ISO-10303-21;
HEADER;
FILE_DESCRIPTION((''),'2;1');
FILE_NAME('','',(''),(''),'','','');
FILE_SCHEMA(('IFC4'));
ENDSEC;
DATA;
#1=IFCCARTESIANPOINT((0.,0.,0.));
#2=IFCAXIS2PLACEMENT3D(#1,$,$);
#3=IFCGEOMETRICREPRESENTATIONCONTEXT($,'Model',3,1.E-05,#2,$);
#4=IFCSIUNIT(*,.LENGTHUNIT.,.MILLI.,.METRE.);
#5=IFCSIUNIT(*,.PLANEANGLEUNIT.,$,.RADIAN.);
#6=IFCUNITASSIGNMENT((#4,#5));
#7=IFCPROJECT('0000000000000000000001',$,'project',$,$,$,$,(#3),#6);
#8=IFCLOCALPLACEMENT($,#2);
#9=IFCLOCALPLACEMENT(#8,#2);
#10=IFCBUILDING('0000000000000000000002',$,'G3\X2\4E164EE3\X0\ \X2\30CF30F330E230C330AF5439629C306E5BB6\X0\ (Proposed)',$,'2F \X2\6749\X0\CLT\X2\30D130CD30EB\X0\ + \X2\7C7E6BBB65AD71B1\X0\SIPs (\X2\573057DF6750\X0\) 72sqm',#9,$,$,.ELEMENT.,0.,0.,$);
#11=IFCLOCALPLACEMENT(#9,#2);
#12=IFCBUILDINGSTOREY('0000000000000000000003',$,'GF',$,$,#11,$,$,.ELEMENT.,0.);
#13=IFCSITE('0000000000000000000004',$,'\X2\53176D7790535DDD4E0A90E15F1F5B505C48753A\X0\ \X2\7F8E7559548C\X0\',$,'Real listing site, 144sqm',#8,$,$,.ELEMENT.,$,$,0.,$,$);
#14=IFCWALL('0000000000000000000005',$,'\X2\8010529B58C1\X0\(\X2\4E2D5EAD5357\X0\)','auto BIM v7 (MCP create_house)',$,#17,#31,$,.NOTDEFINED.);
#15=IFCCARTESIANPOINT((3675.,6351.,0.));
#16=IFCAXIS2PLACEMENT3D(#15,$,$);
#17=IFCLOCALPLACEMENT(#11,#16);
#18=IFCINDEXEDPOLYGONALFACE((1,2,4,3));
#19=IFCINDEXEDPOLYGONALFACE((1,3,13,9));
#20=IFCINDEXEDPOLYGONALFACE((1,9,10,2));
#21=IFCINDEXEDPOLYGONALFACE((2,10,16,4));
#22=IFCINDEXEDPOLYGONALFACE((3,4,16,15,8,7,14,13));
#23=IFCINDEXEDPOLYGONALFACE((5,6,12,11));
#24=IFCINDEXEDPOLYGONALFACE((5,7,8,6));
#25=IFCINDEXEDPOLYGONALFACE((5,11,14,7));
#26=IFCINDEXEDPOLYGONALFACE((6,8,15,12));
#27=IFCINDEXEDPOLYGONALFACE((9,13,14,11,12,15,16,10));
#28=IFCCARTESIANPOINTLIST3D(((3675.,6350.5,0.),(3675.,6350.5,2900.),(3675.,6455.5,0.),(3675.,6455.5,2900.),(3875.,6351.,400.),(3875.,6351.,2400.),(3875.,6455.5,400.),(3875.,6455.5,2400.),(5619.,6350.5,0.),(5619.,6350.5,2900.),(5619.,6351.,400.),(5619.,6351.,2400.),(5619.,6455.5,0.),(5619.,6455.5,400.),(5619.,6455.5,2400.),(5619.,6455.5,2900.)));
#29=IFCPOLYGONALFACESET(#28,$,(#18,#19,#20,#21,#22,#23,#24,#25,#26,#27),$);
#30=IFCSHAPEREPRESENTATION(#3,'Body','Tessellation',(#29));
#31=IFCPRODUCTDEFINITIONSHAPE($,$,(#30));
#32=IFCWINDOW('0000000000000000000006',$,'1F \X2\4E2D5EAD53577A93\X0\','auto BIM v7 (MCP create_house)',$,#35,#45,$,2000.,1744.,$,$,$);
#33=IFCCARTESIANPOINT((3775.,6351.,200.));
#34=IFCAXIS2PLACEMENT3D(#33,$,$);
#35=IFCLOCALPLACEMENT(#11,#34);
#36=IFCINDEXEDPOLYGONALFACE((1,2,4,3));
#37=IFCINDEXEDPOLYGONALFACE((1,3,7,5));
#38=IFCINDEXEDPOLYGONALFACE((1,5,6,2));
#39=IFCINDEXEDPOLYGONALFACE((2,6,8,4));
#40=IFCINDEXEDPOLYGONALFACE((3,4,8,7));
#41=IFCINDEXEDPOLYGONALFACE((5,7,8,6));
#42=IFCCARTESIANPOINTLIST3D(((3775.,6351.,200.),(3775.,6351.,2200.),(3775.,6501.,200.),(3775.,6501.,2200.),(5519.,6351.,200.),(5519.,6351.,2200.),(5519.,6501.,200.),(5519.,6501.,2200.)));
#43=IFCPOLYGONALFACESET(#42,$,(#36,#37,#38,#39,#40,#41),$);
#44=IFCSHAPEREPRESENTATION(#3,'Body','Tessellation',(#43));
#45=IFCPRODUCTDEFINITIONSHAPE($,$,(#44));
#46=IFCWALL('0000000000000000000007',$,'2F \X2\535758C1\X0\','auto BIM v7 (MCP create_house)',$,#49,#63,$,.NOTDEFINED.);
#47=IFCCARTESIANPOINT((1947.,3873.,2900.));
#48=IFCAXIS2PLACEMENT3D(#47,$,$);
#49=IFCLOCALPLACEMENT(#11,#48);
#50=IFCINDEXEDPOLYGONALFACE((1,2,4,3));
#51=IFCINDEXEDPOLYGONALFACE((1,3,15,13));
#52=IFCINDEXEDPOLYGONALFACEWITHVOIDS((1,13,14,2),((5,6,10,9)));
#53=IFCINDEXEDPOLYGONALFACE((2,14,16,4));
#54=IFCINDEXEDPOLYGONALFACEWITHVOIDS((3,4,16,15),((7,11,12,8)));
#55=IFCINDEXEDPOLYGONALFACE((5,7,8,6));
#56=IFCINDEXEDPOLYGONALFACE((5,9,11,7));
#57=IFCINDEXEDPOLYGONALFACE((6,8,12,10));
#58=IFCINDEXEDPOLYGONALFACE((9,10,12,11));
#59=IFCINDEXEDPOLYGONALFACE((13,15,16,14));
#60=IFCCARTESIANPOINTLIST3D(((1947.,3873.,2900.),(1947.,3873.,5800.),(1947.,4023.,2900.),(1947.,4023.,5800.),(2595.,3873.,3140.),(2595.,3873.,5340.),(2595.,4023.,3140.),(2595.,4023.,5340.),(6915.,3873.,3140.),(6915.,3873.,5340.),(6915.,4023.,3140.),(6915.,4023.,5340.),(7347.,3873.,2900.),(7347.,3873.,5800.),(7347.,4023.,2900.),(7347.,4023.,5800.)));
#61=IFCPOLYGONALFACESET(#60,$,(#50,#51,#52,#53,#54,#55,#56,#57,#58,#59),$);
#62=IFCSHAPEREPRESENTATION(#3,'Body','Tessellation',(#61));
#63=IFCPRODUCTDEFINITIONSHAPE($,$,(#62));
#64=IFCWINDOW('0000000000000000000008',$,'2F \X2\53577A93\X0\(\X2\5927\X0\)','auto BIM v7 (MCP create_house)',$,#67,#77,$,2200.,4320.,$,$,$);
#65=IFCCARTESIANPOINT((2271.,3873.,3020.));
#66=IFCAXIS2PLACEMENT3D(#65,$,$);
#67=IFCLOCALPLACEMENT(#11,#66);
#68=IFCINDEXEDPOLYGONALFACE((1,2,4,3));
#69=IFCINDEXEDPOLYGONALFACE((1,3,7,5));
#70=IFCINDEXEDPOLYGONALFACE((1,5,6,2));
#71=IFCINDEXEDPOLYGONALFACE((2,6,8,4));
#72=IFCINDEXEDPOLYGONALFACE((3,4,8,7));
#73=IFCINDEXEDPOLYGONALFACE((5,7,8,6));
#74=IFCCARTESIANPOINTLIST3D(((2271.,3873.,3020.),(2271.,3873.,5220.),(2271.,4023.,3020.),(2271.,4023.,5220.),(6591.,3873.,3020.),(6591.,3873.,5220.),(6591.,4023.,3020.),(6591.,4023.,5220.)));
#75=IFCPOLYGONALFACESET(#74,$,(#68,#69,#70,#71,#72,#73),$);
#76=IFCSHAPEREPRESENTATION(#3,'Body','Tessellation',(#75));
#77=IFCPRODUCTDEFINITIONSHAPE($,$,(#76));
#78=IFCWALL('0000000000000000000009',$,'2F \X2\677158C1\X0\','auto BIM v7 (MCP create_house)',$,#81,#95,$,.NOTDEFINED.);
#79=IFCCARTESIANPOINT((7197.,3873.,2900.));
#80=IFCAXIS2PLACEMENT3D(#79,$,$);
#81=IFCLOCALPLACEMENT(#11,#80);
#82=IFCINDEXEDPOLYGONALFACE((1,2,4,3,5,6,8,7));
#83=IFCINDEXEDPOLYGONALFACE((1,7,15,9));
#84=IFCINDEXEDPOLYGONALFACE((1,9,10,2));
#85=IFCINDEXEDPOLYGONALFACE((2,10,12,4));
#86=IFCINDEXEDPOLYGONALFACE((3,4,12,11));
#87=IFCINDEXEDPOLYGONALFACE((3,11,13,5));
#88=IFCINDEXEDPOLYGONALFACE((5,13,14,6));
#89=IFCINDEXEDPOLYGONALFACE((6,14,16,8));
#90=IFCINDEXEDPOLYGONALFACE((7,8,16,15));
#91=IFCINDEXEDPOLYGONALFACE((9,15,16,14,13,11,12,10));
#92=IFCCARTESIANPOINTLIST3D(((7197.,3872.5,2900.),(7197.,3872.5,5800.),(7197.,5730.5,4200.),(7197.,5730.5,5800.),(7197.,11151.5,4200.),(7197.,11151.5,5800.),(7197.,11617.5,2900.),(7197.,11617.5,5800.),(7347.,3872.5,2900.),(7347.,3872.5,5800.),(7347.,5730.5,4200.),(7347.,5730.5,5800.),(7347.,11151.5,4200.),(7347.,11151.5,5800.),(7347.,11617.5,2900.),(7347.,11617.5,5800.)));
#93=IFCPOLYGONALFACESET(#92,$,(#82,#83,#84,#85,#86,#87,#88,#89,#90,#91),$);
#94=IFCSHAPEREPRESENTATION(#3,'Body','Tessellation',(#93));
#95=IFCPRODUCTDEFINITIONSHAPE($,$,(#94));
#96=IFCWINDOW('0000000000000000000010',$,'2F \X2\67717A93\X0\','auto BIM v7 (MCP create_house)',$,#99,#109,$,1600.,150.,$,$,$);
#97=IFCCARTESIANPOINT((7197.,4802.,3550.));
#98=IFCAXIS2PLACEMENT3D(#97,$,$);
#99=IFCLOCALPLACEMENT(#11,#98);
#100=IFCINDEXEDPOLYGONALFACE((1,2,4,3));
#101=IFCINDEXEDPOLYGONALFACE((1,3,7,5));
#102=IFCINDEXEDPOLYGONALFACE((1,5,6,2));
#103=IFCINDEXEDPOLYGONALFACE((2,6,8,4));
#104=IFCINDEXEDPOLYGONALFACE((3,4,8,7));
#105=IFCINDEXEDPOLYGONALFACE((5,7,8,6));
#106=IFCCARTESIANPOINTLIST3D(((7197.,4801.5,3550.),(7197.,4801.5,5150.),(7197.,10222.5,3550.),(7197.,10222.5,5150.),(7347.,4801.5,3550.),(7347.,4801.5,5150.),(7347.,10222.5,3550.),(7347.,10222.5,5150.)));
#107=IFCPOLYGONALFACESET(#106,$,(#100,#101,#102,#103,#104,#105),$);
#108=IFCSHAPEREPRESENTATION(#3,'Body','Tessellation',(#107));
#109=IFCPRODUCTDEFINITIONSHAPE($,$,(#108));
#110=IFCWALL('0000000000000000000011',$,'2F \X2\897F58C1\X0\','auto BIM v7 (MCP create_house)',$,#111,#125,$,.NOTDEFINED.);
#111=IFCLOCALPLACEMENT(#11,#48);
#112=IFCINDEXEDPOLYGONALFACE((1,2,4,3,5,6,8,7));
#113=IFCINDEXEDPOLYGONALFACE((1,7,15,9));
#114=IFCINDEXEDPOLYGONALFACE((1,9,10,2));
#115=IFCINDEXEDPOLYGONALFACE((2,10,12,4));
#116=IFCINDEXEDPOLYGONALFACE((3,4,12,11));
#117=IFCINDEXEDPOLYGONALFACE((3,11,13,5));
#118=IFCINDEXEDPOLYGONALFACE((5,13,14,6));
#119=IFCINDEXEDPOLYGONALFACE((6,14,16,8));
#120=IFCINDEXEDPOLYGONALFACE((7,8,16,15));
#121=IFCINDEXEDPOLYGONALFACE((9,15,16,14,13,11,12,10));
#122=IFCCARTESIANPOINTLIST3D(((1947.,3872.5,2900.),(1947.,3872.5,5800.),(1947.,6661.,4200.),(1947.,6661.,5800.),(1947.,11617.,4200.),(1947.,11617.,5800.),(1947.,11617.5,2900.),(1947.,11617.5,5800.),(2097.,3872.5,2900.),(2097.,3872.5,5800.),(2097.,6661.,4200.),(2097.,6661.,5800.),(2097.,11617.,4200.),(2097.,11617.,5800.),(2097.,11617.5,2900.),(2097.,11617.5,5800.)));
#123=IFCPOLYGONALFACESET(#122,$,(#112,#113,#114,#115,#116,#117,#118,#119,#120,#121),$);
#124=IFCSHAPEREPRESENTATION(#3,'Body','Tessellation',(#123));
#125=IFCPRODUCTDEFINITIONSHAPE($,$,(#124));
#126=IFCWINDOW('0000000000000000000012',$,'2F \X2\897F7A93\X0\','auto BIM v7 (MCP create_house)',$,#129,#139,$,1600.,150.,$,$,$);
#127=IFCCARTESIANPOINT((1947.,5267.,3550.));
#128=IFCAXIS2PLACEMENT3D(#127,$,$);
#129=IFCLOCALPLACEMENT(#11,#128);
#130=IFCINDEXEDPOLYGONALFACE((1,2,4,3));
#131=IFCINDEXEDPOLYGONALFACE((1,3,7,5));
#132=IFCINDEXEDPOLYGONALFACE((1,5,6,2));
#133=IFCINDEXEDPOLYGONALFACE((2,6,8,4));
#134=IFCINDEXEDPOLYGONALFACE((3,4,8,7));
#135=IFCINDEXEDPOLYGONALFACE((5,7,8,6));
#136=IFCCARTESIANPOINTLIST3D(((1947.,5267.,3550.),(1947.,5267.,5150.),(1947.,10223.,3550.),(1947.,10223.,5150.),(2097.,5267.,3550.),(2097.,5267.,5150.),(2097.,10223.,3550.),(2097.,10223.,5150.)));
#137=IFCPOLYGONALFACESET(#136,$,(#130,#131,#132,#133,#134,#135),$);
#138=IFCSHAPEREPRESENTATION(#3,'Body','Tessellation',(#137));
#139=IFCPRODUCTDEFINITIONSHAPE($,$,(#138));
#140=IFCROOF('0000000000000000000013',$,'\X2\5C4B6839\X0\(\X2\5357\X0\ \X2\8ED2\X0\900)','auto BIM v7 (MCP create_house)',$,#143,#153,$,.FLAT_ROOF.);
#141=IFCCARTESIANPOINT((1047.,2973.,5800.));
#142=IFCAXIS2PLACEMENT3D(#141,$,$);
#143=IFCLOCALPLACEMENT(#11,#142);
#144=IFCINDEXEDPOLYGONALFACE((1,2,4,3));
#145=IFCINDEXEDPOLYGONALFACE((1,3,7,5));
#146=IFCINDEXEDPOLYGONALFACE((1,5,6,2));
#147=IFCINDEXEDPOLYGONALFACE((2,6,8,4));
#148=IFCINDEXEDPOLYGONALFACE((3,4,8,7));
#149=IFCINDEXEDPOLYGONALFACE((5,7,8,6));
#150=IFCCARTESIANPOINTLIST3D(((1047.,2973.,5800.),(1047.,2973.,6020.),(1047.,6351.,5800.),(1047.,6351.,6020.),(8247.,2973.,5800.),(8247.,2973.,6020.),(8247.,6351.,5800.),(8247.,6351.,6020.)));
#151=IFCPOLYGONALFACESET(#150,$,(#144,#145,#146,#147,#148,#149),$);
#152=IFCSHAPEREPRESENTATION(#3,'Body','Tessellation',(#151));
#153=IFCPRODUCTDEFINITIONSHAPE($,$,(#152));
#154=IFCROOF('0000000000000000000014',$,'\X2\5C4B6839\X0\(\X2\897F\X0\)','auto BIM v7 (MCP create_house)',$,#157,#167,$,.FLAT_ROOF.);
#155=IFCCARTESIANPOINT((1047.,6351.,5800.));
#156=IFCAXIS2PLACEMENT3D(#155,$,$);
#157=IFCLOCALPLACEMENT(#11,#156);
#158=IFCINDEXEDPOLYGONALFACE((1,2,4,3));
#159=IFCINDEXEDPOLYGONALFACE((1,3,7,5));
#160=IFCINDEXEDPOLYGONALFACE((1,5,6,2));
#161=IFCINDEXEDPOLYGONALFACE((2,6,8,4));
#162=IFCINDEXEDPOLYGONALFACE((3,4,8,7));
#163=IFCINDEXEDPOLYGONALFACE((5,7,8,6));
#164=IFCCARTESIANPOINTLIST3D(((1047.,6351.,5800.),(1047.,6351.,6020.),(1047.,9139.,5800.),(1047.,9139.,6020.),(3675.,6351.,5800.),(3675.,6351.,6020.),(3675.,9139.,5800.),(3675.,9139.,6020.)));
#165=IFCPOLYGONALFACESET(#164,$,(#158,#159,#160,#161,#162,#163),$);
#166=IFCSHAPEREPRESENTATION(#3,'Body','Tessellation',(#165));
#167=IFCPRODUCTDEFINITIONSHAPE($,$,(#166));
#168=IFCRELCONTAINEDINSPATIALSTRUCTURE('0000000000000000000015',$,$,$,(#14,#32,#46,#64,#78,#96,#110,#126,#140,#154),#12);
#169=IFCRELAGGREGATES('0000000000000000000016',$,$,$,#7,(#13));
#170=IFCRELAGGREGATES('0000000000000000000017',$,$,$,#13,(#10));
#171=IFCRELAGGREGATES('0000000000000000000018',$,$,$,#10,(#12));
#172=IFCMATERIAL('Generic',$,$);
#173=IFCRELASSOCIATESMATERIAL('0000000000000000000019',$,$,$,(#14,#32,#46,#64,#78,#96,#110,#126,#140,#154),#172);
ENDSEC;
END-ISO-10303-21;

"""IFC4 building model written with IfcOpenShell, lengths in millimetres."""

from ifc_helpers import new_model, si_unit, frame, frame_2d, origin, place, context, project, spatial, rectangle, extrude, material, element, fill, save


model = new_model("IFC4")

# Units and contexts
model_context = context("Model", 3, precision=1e-05, world=origin())
ifc_project = project(units=[si_unit("LENGTHUNIT", "METRE", prefix="MILLI"), si_unit("PLANEANGLEUNIT", "RADIAN")], contexts=[model_context])

# Site, building, storey
site_placement = place(None, origin())
site = spatial("IfcSite", under=ifc_project, at=site_placement, Name="北海道川上郡弟子屈町 美留和", ObjectType="Real listing site, 144sqm", CompositionType="ELEMENT", RefElevation=0.0)
building_placement = place(site_placement, origin())
building = spatial("IfcBuilding", under=site, at=building_placement, Name="G3世代 ハンモック吹抜の家 (Proposed)", ObjectType="2F 杉CLTパネル + 籾殻断熱SIPs (地域材) 72sqm", CompositionType="ELEMENT", ElevationOfRefHeight=0.0, ElevationOfTerrain=0.0)
storey_placement = place(building_placement, origin())
storey = spatial("IfcBuildingStorey", under=building, at=storey_placement, Name="GF", CompositionType="ELEMENT", Elevation=0.0)

# Shared definitions
ifc_material = material(Name="Generic")

# Wall, opening, window
wall_1_placement = place(storey_placement, frame((3675.0, 6351.0, 0.0)))
wall_1 = element("IfcWall", 1, at=wall_1_placement, inside=storey, material=ifc_material, Name="耐力壁(中庭南)", Description="auto BIM v7 (MCP create_house)", PredefinedType="NOTDEFINED", context=model_context, shape_type="SweptSolid", body=[
    extrude(rectangle(XDim=1944.0, YDim=105.0, at=frame_2d((972.0, 52.0))), frame((3675.0, 6351.0, 0.0)), (0.0, 0.0, 1.0), 2900.0),
])
opening_1_placement = place(storey_placement, frame((3775.0, 6351.0, 200.0)))
opening_1 = element("IfcOpeningElement", 2, at=opening_1_placement, cuts=wall_1, PredefinedType="NOTDEFINED", context=model_context, shape_type="SweptSolid", body=[
    extrude(rectangle(XDim=1744.0, YDim=150.0, at=frame_2d((872.0, 75.0))), frame((3775.0, 6351.0, 200.0)), (0.0, 0.0, 1.0), 2000.0),
])
window_1_placement = place(storey_placement, frame((3775.0, 6351.0, 200.0)))
window_1 = element("IfcWindow", 3, at=window_1_placement, inside=storey, material=ifc_material, Name="1F 中庭南窓", Description="auto BIM v7 (MCP create_house)", OverallHeight=2000.0, OverallWidth=1744.0, context=model_context, shape_type="SweptSolid", body=[
    extrude(rectangle(XDim=1744.0, YDim=150.0, at=frame_2d((872.0, 75.0))), frame((3775.0, 6351.0, 200.0)), (0.0, 0.0, 1.0), 2000.0),
])
fill(opening_1, window_1)

# Walls, openings, windows
wall_2_placement = place(storey_placement, frame((1947.0, 3873.0, 2900.0)))
wall_2 = element("IfcWall", 4, at=wall_2_placement, inside=storey, material=ifc_material, Name="2F 南壁", Description="auto BIM v7 (MCP create_house)", PredefinedType="NOTDEFINED", context=model_context, shape_type="SweptSolid", body=[
    extrude(rectangle(XDim=5400.0, YDim=150.0, at=frame_2d((2700.0, 75.0))), frame((1947.0, 3873.0, 2900.0)), (0.0, 0.0, 1.0), 2900.0),
])
opening_2_placement = place(storey_placement, frame((2271.0, 3873.0, 3020.0)))
opening_2 = element("IfcOpeningElement", 5, at=opening_2_placement, cuts=wall_2, PredefinedType="NOTDEFINED", context=model_context, shape_type="SweptSolid", body=[
    extrude(rectangle(XDim=4320.0, YDim=150.0, at=frame_2d((2160.0, 75.0))), frame((2271.0, 3873.0, 3020.0)), (0.0, 0.0, 1.0), 2200.0),
])
window_2_placement = place(storey_placement, frame((2271.0, 3873.0, 3020.0)))
window_2 = element("IfcWindow", 6, at=window_2_placement, inside=storey, material=ifc_material, Name="2F 南窓(大)", Description="auto BIM v7 (MCP create_house)", OverallHeight=2200.0, OverallWidth=4320.0, context=model_context, shape_type="SweptSolid", body=[
    extrude(rectangle(XDim=4320.0, YDim=150.0, at=frame_2d((2160.0, 75.0))), frame((2271.0, 3873.0, 3020.0)), (0.0, 0.0, 1.0), 2200.0),
])
fill(opening_2, window_2)
wall_3_placement = place(storey_placement, frame((7197.0, 3873.0, 2900.0)))
wall_3 = element("IfcWall", 7, at=wall_3_placement, inside=storey, material=ifc_material, Name="2F 東壁", Description="auto BIM v7 (MCP create_house)", PredefinedType="NOTDEFINED", context=model_context, shape_type="SweptSolid", body=[
    extrude(rectangle(XDim=150.0, YDim=7745.0, at=frame_2d((75.0, 3872.0))), frame((7197.0, 3873.0, 2900.0)), (0.0, 0.0, 1.0), 2900.0),
])
opening_3_placement = place(storey_placement, frame((7197.0, 4802.0, 3550.0)))
opening_3 = element("IfcOpeningElement", 8, at=opening_3_placement, cuts=wall_3, PredefinedType="NOTDEFINED", context=model_context, shape_type="SweptSolid", body=[
    extrude(rectangle(XDim=150.0, YDim=5421.0, at=frame_2d((75.0, 2710.0))), frame((7197.0, 4802.0, 3550.0)), (0.0, 0.0, 1.0), 1600.0),
])
window_3_placement = place(storey_placement, frame((7197.0, 4802.0, 3550.0)))
window_3 = element("IfcWindow", 9, at=window_3_placement, inside=storey, material=ifc_material, Name="2F 東窓", Description="auto BIM v7 (MCP create_house)", OverallHeight=1600.0, OverallWidth=150.0, context=model_context, shape_type="SweptSolid", body=[
    extrude(rectangle(XDim=150.0, YDim=5421.0, at=frame_2d((75.0, 2710.0))), frame((7197.0, 4802.0, 3550.0)), (0.0, 0.0, 1.0), 1600.0),
])
fill(opening_3, window_3)
wall_4_placement = place(storey_placement, frame((1947.0, 3873.0, 2900.0)))
wall_4 = element("IfcWall", 10, at=wall_4_placement, inside=storey, material=ifc_material, Name="2F 西壁", Description="auto BIM v7 (MCP create_house)", PredefinedType="NOTDEFINED", context=model_context, shape_type="SweptSolid", body=[
    extrude(rectangle(XDim=150.0, YDim=7745.0, at=frame_2d((75.0, 3872.0))), frame((1947.0, 3873.0, 2900.0)), (0.0, 0.0, 1.0), 2900.0),
])
opening_4_placement = place(storey_placement, frame((1947.0, 5267.0, 3550.0)))
opening_4 = element("IfcOpeningElement", 11, at=opening_4_placement, cuts=wall_4, PredefinedType="NOTDEFINED", context=model_context, shape_type="SweptSolid", body=[
    extrude(rectangle(XDim=150.0, YDim=4956.0, at=frame_2d((75.0, 2478.0))), frame((1947.0, 5267.0, 3550.0)), (0.0, 0.0, 1.0), 1600.0),
])
window_4_placement = place(storey_placement, frame((1947.0, 5267.0, 3550.0)))
window_4 = element("IfcWindow", 12, at=window_4_placement, inside=storey, material=ifc_material, Name="2F 西窓", Description="auto BIM v7 (MCP create_house)", OverallHeight=1600.0, OverallWidth=150.0, context=model_context, shape_type="SweptSolid", body=[
    extrude(rectangle(XDim=150.0, YDim=4956.0, at=frame_2d((75.0, 2478.0))), frame((1947.0, 5267.0, 3550.0)), (0.0, 0.0, 1.0), 1600.0),
])
fill(opening_4, window_4)

# Roofs
roof_1_placement = place(storey_placement, frame((1047.0, 2973.0, 5800.0)))
element("IfcRoof", 13, at=roof_1_placement, inside=storey, material=ifc_material, Name="屋根(南 軒900)", Description="auto BIM v7 (MCP create_house)", PredefinedType="FLAT_ROOF", context=model_context, shape_type="SweptSolid", body=[
    extrude(rectangle(XDim=7200.0, YDim=3378.0, at=frame_2d((3600.0, 1689.0))), frame((1047.0, 2973.0, 5800.0)), (0.0, 0.0, 1.0), 220.0),
])
roof_2_placement = place(storey_placement, frame((1047.0, 6351.0, 5800.0)))
element("IfcRoof", 14, at=roof_2_placement, inside=storey, material=ifc_material, Name="屋根(西)", Description="auto BIM v7 (MCP create_house)", PredefinedType="FLAT_ROOF", context=model_context, shape_type="SweptSolid", body=[
    extrude(rectangle(XDim=2628.0, YDim=2788.0, at=frame_2d((1314.0, 1394.0))), frame((1047.0, 6351.0, 5800.0)), (0.0, 0.0, 1.0), 220.0),
])

save(model, "model.ifc")
